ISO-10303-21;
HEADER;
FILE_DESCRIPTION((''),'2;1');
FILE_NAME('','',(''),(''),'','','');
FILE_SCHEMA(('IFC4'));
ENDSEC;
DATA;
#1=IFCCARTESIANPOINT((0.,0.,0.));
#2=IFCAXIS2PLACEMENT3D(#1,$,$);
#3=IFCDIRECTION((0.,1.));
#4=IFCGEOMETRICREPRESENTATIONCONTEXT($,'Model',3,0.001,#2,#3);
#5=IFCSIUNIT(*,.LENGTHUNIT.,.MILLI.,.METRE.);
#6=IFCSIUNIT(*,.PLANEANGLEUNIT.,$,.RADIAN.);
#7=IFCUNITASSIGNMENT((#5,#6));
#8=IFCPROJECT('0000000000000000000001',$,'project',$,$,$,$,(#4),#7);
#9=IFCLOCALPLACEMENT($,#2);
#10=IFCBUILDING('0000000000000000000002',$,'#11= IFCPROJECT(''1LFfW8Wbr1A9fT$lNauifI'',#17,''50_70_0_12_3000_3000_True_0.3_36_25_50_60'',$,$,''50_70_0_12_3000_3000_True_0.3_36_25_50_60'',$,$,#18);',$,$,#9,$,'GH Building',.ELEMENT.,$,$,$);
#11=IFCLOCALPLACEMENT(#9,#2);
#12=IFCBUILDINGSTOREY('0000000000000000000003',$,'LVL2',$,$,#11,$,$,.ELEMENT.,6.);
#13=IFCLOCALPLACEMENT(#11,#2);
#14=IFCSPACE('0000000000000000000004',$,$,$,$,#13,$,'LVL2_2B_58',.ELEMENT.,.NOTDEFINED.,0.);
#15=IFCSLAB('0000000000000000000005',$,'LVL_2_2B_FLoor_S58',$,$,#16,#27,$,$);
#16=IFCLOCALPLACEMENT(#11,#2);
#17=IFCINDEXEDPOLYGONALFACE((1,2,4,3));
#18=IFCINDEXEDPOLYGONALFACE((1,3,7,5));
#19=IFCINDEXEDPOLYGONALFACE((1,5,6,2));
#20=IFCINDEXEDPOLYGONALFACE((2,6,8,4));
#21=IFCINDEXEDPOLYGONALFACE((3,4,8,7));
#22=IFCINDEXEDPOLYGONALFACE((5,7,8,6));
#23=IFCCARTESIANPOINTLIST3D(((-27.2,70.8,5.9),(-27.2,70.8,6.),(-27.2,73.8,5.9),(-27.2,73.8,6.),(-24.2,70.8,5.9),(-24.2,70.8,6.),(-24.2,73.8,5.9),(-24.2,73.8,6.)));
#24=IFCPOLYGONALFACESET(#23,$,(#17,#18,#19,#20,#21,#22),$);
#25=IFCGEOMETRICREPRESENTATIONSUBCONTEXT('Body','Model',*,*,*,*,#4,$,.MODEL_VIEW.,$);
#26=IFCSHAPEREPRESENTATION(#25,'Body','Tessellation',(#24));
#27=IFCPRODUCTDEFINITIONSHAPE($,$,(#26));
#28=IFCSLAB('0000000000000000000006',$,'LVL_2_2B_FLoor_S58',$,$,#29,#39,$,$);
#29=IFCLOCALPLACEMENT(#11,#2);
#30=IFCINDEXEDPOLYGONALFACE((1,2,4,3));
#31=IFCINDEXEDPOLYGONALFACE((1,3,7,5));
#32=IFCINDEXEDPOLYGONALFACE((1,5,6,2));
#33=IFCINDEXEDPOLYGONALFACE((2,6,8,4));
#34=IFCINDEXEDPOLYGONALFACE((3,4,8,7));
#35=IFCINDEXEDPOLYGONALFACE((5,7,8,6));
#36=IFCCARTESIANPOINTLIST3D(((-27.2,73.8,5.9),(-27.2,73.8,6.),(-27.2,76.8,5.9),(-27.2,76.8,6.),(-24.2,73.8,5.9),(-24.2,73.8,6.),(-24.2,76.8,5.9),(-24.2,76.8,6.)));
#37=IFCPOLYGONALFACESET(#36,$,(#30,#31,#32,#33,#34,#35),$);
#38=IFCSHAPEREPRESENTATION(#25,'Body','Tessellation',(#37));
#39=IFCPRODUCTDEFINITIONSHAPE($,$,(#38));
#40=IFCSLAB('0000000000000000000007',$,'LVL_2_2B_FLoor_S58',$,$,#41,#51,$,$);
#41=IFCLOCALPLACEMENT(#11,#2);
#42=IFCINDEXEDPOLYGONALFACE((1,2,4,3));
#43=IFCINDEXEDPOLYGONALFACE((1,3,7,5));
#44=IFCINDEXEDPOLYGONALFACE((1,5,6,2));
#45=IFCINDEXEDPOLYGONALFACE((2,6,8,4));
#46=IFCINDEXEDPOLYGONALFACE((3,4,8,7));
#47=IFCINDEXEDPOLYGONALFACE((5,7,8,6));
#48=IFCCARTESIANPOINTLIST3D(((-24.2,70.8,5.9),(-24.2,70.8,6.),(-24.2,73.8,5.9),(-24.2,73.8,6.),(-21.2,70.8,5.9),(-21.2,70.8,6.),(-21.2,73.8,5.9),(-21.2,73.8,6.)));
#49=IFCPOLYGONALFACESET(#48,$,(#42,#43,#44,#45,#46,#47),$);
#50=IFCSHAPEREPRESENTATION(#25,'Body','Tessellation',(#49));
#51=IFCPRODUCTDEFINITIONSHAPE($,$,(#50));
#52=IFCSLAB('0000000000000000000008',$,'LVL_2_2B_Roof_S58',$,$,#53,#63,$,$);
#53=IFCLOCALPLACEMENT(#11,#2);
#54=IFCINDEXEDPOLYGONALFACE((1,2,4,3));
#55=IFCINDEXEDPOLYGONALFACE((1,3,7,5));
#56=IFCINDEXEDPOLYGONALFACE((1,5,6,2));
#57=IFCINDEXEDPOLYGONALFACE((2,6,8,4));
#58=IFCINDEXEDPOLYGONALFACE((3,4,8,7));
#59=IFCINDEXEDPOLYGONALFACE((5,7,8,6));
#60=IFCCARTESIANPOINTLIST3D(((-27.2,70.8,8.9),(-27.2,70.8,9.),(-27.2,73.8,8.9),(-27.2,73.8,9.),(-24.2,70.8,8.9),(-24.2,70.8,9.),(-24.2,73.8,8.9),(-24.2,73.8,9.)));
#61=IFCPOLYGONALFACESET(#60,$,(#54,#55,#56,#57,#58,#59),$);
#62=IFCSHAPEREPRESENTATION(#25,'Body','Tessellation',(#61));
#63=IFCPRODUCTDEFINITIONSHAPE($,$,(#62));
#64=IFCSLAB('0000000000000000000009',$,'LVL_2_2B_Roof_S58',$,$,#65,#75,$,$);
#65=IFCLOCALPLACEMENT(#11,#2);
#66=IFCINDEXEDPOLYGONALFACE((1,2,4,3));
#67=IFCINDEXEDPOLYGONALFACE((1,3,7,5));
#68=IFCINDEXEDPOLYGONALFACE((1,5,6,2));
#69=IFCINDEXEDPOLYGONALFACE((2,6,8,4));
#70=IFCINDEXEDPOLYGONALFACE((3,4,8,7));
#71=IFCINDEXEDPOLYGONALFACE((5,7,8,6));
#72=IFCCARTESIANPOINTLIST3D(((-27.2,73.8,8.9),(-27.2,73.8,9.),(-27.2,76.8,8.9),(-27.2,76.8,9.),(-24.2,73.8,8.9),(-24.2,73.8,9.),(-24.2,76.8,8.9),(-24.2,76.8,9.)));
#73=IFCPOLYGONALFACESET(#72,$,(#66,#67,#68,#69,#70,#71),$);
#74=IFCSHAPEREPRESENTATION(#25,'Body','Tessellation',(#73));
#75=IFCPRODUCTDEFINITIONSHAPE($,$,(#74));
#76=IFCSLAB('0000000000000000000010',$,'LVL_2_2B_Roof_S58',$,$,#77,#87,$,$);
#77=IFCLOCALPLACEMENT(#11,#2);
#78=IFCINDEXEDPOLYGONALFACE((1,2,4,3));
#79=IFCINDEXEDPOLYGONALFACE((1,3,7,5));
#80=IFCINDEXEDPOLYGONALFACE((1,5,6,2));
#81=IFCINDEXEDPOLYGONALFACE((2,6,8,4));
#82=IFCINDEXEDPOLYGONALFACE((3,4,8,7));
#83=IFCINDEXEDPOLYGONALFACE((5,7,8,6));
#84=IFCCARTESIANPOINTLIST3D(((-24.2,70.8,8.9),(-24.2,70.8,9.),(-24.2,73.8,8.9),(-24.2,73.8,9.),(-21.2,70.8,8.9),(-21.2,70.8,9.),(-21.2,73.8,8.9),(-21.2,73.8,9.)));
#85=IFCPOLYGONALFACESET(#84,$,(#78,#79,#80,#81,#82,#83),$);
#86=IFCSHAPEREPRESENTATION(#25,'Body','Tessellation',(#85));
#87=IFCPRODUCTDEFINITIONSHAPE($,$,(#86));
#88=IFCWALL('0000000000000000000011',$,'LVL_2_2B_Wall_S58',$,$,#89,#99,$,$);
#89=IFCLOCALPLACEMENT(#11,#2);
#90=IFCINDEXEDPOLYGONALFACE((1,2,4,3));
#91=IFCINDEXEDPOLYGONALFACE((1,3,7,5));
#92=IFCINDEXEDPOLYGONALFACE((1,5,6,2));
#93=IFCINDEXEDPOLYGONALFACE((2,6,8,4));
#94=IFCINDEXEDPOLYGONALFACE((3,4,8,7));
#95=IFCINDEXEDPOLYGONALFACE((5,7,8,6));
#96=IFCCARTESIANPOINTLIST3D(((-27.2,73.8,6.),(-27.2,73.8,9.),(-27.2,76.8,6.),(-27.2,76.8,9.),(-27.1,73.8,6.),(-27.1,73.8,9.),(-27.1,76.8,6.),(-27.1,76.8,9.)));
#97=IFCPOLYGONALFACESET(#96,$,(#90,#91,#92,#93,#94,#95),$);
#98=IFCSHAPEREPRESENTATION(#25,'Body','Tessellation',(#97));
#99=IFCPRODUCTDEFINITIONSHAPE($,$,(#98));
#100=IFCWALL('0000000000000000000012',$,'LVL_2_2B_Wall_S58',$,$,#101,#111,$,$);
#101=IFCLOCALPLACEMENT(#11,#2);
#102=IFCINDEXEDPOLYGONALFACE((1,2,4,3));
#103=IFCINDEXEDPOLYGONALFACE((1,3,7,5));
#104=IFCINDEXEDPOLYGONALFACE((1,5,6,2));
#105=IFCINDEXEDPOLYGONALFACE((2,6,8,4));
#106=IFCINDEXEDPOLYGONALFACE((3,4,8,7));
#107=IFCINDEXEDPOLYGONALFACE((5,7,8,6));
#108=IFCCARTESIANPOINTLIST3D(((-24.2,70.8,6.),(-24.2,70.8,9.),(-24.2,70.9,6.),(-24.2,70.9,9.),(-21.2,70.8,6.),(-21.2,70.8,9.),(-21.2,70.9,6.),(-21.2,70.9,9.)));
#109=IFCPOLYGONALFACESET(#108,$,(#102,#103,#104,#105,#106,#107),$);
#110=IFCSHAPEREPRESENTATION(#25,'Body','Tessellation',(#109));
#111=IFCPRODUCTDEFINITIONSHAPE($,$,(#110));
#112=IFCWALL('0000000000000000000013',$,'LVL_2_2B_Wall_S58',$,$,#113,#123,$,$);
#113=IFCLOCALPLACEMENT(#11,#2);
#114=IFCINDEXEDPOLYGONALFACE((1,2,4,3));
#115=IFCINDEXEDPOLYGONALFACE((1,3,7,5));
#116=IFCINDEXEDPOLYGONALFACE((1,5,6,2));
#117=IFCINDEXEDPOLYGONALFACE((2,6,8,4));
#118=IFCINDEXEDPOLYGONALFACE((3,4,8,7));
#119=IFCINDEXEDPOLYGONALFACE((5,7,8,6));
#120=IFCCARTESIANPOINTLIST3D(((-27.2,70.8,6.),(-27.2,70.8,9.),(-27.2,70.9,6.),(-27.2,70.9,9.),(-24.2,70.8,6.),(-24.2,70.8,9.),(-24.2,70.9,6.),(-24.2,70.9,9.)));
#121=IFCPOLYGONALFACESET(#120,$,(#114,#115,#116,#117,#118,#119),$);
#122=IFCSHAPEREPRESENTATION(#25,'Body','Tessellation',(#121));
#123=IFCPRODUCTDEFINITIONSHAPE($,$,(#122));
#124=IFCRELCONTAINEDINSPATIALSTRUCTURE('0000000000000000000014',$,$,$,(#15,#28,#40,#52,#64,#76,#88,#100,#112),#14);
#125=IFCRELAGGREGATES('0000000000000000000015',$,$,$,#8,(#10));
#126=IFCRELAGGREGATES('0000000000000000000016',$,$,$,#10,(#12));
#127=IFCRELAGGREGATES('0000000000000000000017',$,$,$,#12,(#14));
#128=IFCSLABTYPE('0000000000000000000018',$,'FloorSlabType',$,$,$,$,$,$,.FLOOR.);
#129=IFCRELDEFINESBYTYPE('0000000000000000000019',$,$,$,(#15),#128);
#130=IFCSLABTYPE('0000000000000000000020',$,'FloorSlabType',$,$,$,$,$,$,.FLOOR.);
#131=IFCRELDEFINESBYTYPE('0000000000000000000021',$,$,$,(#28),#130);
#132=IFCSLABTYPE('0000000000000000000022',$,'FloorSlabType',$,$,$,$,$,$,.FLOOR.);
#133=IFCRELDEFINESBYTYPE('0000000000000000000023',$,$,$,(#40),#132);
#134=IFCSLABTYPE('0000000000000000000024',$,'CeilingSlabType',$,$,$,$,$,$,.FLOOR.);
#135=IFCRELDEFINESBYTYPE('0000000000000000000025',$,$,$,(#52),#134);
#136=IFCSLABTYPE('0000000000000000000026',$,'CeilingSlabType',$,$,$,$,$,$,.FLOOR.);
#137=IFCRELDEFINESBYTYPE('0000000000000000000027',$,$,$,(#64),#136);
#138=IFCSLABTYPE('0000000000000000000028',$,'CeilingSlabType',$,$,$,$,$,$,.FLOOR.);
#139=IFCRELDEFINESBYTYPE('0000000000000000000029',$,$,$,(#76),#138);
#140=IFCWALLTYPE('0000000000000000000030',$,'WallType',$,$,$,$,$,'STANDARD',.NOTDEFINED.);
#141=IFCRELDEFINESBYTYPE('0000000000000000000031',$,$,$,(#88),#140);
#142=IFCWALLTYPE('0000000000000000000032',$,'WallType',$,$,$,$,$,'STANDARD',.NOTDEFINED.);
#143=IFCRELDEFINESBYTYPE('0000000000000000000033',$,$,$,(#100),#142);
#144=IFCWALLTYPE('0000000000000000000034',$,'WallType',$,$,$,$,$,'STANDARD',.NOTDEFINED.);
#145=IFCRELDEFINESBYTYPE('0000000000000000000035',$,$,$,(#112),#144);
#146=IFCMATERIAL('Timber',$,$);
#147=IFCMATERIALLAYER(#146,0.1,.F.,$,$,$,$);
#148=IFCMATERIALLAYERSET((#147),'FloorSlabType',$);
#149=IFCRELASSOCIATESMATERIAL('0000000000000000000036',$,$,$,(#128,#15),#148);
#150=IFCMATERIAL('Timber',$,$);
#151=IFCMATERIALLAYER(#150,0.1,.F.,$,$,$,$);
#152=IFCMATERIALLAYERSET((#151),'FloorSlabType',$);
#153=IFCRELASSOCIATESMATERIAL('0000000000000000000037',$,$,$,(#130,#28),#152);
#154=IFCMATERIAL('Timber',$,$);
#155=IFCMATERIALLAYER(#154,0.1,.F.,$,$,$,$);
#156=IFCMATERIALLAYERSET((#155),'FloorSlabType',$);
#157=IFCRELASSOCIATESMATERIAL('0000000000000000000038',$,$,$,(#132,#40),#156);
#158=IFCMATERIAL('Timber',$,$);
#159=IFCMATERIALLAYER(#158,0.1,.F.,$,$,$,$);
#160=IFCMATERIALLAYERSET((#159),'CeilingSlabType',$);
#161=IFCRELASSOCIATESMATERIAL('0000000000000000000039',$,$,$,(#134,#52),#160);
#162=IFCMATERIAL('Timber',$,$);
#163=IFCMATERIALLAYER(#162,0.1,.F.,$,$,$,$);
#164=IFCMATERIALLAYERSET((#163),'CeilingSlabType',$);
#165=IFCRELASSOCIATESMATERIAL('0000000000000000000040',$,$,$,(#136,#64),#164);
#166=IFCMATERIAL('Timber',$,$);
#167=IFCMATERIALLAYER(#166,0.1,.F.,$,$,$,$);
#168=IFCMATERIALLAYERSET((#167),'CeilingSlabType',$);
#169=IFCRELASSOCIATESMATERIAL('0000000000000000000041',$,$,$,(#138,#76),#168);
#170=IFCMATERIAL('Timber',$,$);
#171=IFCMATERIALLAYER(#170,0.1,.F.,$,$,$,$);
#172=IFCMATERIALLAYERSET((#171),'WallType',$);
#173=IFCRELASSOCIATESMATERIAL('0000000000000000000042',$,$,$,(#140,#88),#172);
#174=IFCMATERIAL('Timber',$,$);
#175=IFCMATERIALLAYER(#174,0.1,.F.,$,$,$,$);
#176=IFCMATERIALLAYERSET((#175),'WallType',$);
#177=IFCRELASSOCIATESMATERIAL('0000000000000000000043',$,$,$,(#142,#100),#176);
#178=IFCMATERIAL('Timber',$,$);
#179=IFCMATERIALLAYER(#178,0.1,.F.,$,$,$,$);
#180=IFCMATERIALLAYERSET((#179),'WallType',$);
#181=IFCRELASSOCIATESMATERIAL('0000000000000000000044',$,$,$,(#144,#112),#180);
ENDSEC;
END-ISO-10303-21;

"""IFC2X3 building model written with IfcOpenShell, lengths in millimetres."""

from ifc_helpers import new_model, si_unit, direction, frame, frame_2d, origin, place, context, subcontext, project, spatial, rectangle, extrude, material, layer, layer_set, layer_usage, type_object, element, save


model = new_model("IFC2X3")

# Units and contexts
model_context = context("Model", 3, precision=0.001, world=origin(), true_north=direction((0.0, 1.0)))
body_context = subcontext(model_context, "Body", "Model", "MODEL_VIEW")
ifc_project = project(units=[si_unit("LENGTHUNIT", "METRE", prefix="MILLI"), si_unit("PLANEANGLEUNIT", "RADIAN")], contexts=[model_context])

# Building, storey
building_placement = place(None, origin())
building = spatial("IfcBuilding", under=ifc_project, at=building_placement, Name="#11= IFCPROJECT('1LFfW8Wbr1A9fT$lNauifI',#17,'50_70_0_12_3000_3000_True_0.3_36_25_50_60',$,$,'50_70_0_12_3000_3000_True_0.3_36_25_50_60',$,$,#18);", LongName="GH Building", CompositionType="ELEMENT")
storey_placement = place(building_placement, origin())
storey = spatial("IfcBuildingStorey", under=building, at=storey_placement, Name="LVL2", CompositionType="ELEMENT", Elevation=6.0)

# Shared definitions
space_1_placement = place(storey_placement, origin())
space_1 = spatial("IfcSpace", under=storey, at=space_1_placement, LongName="LVL2_2B_58", CompositionType="ELEMENT", InteriorOrExteriorSpace="NOTDEFINED", ElevationWithFlooring=0.0)

# Slabs
ifc_material_1 = material(Name="Timber")
ifc_layer_1 = layer(ifc_material_1, 0.1, ventilated=False)
ifc_layer_set_1 = layer_set([ifc_layer_1], Name="FloorSlabType")
ifc_layer_usage_1 = layer_usage(ifc_layer_set_1, "AXIS3", "NEGATIVE", -0.1)
slab_type_1 = type_object("IfcSlabType", Name="FloorSlabType", PredefinedType="FLOOR", material=ifc_layer_set_1)
slab_1_placement = place(space_1_placement, frame((-24.2, 70.8, 5.9), z_axis=(0.0, 0.0, 1.0), x_axis=(0.0, 1.0, 0.0)))
element("IfcSlab", 1, at=slab_1_placement, inside=space_1, type_object=slab_type_1, material=ifc_layer_usage_1, Name="LVL_2_2B_FLoor_S58", context=body_context, shape_type="SweptSolid", body=[
    extrude(rectangle(XDim=3.0, YDim=3.0, at=frame_2d((1.5, 1.5))), origin(), (0.0, 0.0, 1.0), 0.1),
])
ifc_material_2 = material(Name="Timber")
ifc_layer_2 = layer(ifc_material_2, 0.1, ventilated=False)
ifc_layer_set_2 = layer_set([ifc_layer_2], Name="FloorSlabType")
ifc_layer_usage_2 = layer_usage(ifc_layer_set_2, "AXIS3", "NEGATIVE", -0.1)
slab_type_2 = type_object("IfcSlabType", Name="FloorSlabType", PredefinedType="FLOOR", material=ifc_layer_set_2)
slab_2_placement = place(space_1_placement, frame((-24.2, 73.8, 5.9), z_axis=(0.0, 0.0, 1.0), x_axis=(0.0, 1.0, 0.0)))
element("IfcSlab", 2, at=slab_2_placement, inside=space_1, type_object=slab_type_2, material=ifc_layer_usage_2, Name="LVL_2_2B_FLoor_S58", context=body_context, shape_type="SweptSolid", body=[
    extrude(rectangle(XDim=3.0, YDim=3.0, at=frame_2d((1.5, 1.5))), origin(), (0.0, 0.0, 1.0), 0.1),
])
ifc_material_3 = material(Name="Timber")
ifc_layer_3 = layer(ifc_material_3, 0.1, ventilated=False)
ifc_layer_set_3 = layer_set([ifc_layer_3], Name="FloorSlabType")
ifc_layer_usage_3 = layer_usage(ifc_layer_set_3, "AXIS3", "NEGATIVE", -0.1)
slab_type_3 = type_object("IfcSlabType", Name="FloorSlabType", PredefinedType="FLOOR", material=ifc_layer_set_3)
slab_3_placement = place(space_1_placement, frame((-21.2, 70.8, 5.9), z_axis=(0.0, 0.0, 1.0), x_axis=(0.0, 1.0, 0.0)))
element("IfcSlab", 3, at=slab_3_placement, inside=space_1, type_object=slab_type_3, material=ifc_layer_usage_3, Name="LVL_2_2B_FLoor_S58", context=body_context, shape_type="SweptSolid", body=[
    extrude(rectangle(XDim=3.0, YDim=3.0, at=frame_2d((1.5, 1.5))), origin(), (0.0, 0.0, 1.0), 0.1),
])
ifc_material_4 = material(Name="Timber")
ifc_layer_4 = layer(ifc_material_4, 0.1, ventilated=False)
ifc_layer_set_4 = layer_set([ifc_layer_4], Name="CeilingSlabType")
ifc_layer_usage_4 = layer_usage(ifc_layer_set_4, "AXIS3", "NEGATIVE", -0.1)
slab_type_4 = type_object("IfcSlabType", Name="CeilingSlabType", PredefinedType="FLOOR", material=ifc_layer_set_4)
slab_4_placement = place(space_1_placement, frame((-24.2, 70.8, 8.9), z_axis=(0.0, 0.0, 1.0), x_axis=(0.0, 1.0, 0.0)))
element("IfcSlab", 4, at=slab_4_placement, inside=space_1, type_object=slab_type_4, material=ifc_layer_usage_4, Name="LVL_2_2B_Roof_S58", context=body_context, shape_type="SweptSolid", body=[
    extrude(rectangle(XDim=3.0, YDim=3.0, at=frame_2d((1.5, 1.5))), origin(), (0.0, 0.0, 1.0), 0.1),
])
ifc_material_5 = material(Name="Timber")
ifc_layer_5 = layer(ifc_material_5, 0.1, ventilated=False)
ifc_layer_set_5 = layer_set([ifc_layer_5], Name="CeilingSlabType")
ifc_layer_usage_5 = layer_usage(ifc_layer_set_5, "AXIS3", "NEGATIVE", -0.1)
slab_type_5 = type_object("IfcSlabType", Name="CeilingSlabType", PredefinedType="FLOOR", material=ifc_layer_set_5)
slab_5_placement = place(space_1_placement, frame((-24.2, 73.8, 8.9), z_axis=(0.0, 0.0, 1.0), x_axis=(0.0, 1.0, 0.0)))
element("IfcSlab", 5, at=slab_5_placement, inside=space_1, type_object=slab_type_5, material=ifc_layer_usage_5, Name="LVL_2_2B_Roof_S58", context=body_context, shape_type="SweptSolid", body=[
    extrude(rectangle(XDim=3.0, YDim=3.0, at=frame_2d((1.5, 1.5))), origin(), (0.0, 0.0, 1.0), 0.1),
])
ifc_material_6 = material(Name="Timber")
ifc_layer_6 = layer(ifc_material_6, 0.1, ventilated=False)
ifc_layer_set_6 = layer_set([ifc_layer_6], Name="CeilingSlabType")
ifc_layer_usage_6 = layer_usage(ifc_layer_set_6, "AXIS3", "NEGATIVE", -0.1)
slab_type_6 = type_object("IfcSlabType", Name="CeilingSlabType", PredefinedType="FLOOR", material=ifc_layer_set_6)
slab_6_placement = place(space_1_placement, frame((-21.2, 70.8, 8.9), z_axis=(0.0, 0.0, 1.0), x_axis=(0.0, 1.0, 0.0)))
element("IfcSlab", 6, at=slab_6_placement, inside=space_1, type_object=slab_type_6, material=ifc_layer_usage_6, Name="LVL_2_2B_Roof_S58", context=body_context, shape_type="SweptSolid", body=[
    extrude(rectangle(XDim=3.0, YDim=3.0, at=frame_2d((1.5, 1.5))), origin(), (0.0, 0.0, 1.0), 0.1),
])

# Walls
ifc_material_7 = material(Name="Timber")
ifc_layer_7 = layer(ifc_material_7, 0.1, ventilated=False)
ifc_layer_set_7 = layer_set([ifc_layer_7], Name="WallType")
ifc_layer_usage_7 = layer_usage(ifc_layer_set_7, "AXIS2", "NEGATIVE", 0.0)
wall_type_1 = type_object("IfcWallType", Name="WallType", ElementType="STANDARD", PredefinedType="NOTDEFINED", material=ifc_layer_set_7)
wall_1_placement = place(space_1_placement, frame((-27.2, 73.8, 6.0), z_axis=(0.0, 0.0, 1.0), x_axis=(0.0, 1.0, 0.0)))
element("IfcWall", 7, at=wall_1_placement, inside=space_1, type_object=wall_type_1, material=ifc_layer_usage_7, Name="LVL_2_2B_Wall_S58", context=body_context, shape_type="SweptSolid", body=[
    extrude(rectangle(XDim=3.0, YDim=0.1, at=frame_2d((1.5, -0.1))), origin(), (0.0, 0.0, 1.0), 3.0),
])
ifc_material_8 = material(Name="Timber")
ifc_layer_8 = layer(ifc_material_8, 0.1, ventilated=False)
ifc_layer_set_8 = layer_set([ifc_layer_8], Name="WallType")
ifc_layer_usage_8 = layer_usage(ifc_layer_set_8, "AXIS2", "NEGATIVE", 0.0)
wall_type_2 = type_object("IfcWallType", Name="WallType", ElementType="STANDARD", PredefinedType="NOTDEFINED", material=ifc_layer_set_8)
wall_2_placement = place(space_1_placement, frame((-21.2, 70.8, 6.0), z_axis=(0.0, 0.0, 1.0), x_axis=(-1.0, 0.0, 0.0)))
element("IfcWall", 8, at=wall_2_placement, inside=space_1, type_object=wall_type_2, material=ifc_layer_usage_8, Name="LVL_2_2B_Wall_S58", context=body_context, shape_type="SweptSolid", body=[
    extrude(rectangle(XDim=3.0, YDim=0.1, at=frame_2d((1.5, -0.1))), origin(), (0.0, 0.0, 1.0), 3.0),
])
ifc_material_9 = material(Name="Timber")
ifc_layer_9 = layer(ifc_material_9, 0.1, ventilated=False)
ifc_layer_set_9 = layer_set([ifc_layer_9], Name="WallType")
ifc_layer_usage_9 = layer_usage(ifc_layer_set_9, "AXIS2", "NEGATIVE", 0.0)
wall_type_3 = type_object("IfcWallType", Name="WallType", ElementType="STANDARD", PredefinedType="NOTDEFINED", material=ifc_layer_set_9)
wall_3_placement = place(space_1_placement, frame((-24.2, 70.8, 6.0), z_axis=(0.0, 0.0, 1.0), x_axis=(-1.0, 0.0, 0.0)))
element("IfcWall", 9, at=wall_3_placement, inside=space_1, type_object=wall_type_3, material=ifc_layer_usage_9, Name="LVL_2_2B_Wall_S58", context=body_context, shape_type="SweptSolid", body=[
    extrude(rectangle(XDim=3.0, YDim=0.1, at=frame_2d((1.5, -0.1))), origin(), (0.0, 0.0, 1.0), 3.0),
])

save(model, "model.ifc")
